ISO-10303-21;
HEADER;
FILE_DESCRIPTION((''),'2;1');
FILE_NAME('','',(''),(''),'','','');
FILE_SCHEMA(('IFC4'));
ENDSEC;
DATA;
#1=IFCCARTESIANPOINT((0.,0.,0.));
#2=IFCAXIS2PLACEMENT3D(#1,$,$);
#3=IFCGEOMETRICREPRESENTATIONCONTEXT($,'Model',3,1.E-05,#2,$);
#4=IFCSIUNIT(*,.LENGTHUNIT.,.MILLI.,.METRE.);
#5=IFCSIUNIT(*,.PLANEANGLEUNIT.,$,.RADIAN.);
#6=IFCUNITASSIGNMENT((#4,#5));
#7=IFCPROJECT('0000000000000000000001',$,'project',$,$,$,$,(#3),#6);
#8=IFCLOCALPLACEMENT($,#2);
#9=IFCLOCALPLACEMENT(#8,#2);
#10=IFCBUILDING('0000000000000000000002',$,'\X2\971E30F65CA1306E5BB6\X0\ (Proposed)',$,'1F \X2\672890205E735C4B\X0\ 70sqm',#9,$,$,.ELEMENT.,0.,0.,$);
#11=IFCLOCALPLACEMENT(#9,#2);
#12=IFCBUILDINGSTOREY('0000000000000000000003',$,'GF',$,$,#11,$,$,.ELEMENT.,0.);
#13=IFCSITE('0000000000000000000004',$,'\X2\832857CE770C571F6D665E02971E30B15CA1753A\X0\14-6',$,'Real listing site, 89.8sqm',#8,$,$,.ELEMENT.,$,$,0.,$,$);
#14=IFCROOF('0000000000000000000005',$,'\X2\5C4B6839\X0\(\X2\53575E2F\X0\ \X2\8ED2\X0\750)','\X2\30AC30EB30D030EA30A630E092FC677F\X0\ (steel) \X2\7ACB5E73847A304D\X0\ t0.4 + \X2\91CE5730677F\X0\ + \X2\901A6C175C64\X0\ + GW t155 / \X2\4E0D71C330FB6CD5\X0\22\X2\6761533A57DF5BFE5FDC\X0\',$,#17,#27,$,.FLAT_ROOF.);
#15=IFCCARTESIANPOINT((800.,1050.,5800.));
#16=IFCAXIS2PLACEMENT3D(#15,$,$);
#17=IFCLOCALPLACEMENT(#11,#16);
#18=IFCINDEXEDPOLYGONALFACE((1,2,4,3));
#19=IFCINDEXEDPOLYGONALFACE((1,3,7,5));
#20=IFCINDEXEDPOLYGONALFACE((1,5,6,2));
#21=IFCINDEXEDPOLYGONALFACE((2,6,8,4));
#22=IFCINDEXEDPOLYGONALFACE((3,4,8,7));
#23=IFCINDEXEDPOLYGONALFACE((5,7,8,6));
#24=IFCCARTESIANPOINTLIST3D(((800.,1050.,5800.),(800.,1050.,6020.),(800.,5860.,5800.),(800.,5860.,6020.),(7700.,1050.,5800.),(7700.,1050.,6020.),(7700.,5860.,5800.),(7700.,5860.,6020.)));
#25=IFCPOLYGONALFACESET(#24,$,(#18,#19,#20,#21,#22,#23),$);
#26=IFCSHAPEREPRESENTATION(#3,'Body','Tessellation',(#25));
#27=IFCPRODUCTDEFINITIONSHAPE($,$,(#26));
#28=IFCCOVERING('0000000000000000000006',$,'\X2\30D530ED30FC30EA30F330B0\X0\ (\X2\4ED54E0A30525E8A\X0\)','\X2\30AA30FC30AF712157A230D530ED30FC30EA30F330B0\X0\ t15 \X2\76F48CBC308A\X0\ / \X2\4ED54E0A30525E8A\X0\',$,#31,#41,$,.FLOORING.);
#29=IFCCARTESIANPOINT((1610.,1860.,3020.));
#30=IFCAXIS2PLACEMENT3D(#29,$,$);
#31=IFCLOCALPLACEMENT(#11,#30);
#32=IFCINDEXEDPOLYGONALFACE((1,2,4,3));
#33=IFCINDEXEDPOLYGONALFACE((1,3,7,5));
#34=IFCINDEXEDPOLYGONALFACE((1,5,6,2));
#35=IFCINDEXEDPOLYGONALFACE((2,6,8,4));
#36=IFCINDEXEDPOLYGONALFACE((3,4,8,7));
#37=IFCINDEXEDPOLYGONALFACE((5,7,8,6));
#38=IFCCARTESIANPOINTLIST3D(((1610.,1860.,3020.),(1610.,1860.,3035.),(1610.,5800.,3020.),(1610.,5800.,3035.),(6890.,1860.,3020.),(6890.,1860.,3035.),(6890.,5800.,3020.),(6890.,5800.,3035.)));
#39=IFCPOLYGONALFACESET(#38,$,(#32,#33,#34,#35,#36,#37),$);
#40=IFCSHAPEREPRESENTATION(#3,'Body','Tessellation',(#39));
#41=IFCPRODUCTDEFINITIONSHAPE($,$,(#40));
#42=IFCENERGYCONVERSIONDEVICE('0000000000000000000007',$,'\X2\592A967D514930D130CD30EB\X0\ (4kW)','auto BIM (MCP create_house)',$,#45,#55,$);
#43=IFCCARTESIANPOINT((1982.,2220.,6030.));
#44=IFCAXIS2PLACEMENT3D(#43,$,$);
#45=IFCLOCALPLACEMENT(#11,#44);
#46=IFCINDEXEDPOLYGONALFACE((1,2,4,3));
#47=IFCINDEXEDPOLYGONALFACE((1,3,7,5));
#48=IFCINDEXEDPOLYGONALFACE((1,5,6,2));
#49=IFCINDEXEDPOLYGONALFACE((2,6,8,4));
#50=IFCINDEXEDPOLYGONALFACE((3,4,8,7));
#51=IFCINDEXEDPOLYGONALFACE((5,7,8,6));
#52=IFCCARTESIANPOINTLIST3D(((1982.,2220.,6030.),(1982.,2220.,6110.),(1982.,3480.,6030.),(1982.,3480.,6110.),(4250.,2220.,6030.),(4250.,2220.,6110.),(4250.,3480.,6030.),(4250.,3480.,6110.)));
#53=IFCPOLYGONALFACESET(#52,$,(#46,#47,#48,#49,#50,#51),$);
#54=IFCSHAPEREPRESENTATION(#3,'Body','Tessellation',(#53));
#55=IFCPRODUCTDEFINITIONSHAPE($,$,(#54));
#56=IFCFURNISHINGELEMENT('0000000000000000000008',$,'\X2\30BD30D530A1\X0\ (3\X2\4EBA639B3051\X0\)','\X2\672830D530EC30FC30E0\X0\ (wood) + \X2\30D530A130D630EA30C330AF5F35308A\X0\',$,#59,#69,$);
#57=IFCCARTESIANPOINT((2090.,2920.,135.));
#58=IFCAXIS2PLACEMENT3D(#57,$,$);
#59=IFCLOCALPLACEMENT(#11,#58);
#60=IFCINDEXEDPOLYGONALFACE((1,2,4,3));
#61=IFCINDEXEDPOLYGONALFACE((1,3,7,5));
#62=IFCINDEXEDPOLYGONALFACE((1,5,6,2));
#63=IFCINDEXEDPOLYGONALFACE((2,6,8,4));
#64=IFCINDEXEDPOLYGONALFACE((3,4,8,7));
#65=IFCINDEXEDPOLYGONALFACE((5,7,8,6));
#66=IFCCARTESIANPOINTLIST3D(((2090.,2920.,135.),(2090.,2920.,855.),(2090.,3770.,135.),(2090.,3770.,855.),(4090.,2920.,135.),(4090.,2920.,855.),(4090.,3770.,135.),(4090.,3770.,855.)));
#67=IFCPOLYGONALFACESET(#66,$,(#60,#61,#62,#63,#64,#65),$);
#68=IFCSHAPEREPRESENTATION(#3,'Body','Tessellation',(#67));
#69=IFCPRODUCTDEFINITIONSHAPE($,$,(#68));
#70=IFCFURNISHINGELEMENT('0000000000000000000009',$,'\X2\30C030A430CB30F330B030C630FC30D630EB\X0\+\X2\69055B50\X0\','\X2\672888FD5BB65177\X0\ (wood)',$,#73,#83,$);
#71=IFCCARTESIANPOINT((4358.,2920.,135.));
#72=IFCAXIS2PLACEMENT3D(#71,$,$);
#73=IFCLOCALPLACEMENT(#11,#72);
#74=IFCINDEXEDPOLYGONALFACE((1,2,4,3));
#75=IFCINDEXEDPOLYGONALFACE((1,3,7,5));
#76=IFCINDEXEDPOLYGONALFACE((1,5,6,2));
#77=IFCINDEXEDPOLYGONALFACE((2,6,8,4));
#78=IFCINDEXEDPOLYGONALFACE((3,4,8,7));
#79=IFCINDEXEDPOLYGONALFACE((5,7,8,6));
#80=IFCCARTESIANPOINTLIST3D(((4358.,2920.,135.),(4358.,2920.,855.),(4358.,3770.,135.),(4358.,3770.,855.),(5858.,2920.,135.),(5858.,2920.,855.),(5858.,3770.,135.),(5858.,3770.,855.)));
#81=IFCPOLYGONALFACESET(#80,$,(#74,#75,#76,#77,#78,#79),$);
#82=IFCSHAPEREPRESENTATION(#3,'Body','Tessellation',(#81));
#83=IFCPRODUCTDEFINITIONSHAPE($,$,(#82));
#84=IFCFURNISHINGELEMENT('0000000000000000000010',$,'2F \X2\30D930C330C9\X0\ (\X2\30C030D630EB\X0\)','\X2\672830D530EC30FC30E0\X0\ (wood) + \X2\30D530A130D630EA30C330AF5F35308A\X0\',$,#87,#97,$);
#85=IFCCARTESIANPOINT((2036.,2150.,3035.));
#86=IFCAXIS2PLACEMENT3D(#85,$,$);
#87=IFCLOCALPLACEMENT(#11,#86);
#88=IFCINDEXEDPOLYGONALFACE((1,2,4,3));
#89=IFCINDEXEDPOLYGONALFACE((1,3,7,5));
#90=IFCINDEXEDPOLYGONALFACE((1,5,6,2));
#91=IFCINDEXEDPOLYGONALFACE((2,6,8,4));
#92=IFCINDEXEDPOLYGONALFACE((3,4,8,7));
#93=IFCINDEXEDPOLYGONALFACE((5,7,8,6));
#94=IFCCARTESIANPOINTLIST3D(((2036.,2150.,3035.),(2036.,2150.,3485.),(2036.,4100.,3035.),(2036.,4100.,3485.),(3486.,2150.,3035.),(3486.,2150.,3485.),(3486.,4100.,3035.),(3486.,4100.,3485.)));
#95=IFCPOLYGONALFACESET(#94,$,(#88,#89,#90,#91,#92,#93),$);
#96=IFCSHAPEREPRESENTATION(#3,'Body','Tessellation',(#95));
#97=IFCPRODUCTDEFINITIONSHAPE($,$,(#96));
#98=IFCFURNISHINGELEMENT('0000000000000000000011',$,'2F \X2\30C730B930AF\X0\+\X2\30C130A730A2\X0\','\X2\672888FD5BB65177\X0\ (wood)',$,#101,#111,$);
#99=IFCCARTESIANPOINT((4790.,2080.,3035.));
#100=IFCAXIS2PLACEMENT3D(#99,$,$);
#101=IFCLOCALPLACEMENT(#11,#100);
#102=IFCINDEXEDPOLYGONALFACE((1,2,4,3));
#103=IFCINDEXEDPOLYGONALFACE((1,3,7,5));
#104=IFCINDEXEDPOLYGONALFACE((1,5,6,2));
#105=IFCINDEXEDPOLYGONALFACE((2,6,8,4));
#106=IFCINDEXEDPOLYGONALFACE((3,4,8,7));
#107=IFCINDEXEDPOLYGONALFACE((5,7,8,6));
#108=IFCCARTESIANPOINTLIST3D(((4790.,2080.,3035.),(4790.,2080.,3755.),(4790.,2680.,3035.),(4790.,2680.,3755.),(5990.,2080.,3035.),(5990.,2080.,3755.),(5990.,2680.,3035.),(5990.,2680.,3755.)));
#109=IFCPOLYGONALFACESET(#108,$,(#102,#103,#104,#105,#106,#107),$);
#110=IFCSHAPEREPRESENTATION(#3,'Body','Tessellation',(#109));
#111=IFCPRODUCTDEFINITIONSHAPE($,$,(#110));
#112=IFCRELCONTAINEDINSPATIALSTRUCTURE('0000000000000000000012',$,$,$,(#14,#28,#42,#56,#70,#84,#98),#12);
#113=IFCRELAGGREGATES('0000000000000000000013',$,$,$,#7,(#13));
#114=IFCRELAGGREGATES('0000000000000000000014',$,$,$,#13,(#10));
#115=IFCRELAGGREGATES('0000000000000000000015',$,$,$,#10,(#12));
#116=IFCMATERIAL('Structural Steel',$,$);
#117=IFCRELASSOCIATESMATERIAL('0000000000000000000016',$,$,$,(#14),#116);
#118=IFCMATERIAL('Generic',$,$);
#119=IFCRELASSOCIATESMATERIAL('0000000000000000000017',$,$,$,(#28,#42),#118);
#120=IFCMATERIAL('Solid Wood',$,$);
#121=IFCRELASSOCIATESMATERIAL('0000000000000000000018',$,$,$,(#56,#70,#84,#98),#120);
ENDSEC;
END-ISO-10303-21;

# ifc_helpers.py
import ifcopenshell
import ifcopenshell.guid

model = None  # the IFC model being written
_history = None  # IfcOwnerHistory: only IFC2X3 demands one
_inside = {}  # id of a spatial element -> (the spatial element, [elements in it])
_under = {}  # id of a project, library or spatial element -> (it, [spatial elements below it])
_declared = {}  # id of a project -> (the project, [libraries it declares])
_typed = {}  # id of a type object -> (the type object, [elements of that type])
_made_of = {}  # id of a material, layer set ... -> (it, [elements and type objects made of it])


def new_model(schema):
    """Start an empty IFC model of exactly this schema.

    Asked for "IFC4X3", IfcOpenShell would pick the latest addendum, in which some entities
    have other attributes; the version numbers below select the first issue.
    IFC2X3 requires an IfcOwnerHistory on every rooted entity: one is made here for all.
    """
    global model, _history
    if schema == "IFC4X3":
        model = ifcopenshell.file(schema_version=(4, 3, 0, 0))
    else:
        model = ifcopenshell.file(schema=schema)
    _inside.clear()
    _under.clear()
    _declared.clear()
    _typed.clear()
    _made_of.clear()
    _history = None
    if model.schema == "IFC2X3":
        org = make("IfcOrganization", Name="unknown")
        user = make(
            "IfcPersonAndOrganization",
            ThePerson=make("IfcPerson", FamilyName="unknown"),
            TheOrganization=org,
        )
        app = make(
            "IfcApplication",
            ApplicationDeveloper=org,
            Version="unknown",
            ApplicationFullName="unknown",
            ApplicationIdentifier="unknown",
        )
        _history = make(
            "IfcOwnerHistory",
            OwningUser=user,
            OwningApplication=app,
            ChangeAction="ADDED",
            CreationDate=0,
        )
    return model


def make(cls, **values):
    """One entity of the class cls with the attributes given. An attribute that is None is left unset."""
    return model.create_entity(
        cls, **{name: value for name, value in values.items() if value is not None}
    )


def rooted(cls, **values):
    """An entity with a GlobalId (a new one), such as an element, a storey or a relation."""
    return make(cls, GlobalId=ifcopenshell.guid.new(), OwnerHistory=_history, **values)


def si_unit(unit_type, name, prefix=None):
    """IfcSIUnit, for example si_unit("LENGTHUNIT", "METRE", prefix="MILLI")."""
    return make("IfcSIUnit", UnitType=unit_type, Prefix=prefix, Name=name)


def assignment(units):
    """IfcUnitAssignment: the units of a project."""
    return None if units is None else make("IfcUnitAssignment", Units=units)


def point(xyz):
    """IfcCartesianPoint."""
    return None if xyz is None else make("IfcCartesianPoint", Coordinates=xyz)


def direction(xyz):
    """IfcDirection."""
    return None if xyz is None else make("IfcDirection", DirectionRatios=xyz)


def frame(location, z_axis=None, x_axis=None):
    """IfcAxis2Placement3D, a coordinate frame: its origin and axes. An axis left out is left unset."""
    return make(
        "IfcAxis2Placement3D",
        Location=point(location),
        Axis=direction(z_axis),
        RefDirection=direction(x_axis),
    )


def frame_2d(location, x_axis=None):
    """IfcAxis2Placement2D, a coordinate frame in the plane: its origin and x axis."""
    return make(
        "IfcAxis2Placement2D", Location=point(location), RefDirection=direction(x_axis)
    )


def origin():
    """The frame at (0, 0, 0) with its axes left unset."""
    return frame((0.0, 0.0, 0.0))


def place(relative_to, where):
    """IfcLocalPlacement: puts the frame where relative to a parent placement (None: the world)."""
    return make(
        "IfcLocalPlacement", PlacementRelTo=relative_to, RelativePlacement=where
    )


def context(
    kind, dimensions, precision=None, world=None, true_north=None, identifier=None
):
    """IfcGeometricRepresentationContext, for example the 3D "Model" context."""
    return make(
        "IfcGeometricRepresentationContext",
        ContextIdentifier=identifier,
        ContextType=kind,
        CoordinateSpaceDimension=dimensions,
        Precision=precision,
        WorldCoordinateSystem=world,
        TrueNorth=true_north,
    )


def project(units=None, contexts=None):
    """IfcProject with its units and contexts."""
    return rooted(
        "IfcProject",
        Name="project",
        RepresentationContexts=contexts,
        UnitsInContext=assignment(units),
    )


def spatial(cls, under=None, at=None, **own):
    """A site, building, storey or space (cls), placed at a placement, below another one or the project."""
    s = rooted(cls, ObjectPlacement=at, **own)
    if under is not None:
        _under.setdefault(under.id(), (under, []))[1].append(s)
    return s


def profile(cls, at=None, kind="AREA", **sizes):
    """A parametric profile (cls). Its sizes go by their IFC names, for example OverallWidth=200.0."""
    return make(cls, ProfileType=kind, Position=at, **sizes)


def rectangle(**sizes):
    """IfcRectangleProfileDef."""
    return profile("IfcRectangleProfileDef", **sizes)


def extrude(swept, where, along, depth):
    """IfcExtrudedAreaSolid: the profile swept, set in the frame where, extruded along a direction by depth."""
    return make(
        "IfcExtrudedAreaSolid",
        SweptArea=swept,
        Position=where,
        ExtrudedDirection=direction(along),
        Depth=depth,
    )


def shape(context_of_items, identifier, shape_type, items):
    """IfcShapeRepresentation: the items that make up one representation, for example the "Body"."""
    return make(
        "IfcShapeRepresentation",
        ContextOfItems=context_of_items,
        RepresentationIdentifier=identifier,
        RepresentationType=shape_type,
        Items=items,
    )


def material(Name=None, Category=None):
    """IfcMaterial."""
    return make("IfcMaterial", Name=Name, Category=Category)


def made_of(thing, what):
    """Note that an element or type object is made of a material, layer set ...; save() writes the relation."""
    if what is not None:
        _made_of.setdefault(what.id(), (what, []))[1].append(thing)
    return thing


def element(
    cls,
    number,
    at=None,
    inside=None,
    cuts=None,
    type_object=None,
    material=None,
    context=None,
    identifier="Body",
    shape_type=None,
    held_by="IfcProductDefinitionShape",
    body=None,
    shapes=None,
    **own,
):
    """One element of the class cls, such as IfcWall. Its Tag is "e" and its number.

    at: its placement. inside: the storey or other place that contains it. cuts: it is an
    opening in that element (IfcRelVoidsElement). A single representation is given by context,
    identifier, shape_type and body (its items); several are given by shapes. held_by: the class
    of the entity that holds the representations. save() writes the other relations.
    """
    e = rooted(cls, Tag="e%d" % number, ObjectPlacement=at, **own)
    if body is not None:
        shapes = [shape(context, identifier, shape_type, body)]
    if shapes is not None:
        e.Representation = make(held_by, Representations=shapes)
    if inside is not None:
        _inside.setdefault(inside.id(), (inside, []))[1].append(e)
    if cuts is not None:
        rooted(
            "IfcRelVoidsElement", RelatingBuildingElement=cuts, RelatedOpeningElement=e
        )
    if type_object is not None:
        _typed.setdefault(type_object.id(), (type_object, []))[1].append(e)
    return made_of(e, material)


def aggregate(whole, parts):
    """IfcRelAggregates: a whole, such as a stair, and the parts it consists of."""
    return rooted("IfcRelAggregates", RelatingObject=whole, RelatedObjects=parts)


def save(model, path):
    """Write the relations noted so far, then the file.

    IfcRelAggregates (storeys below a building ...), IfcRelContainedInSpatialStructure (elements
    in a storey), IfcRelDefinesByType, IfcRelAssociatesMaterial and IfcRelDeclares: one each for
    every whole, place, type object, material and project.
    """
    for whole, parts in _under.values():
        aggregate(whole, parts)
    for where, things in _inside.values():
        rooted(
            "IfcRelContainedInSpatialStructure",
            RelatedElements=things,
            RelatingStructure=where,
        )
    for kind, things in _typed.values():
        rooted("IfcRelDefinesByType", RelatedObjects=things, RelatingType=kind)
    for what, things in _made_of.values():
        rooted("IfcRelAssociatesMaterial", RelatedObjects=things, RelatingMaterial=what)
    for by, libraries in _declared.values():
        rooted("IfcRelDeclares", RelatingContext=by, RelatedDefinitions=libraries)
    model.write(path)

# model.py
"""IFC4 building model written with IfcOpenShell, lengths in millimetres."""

from ifc_helpers import new_model, si_unit, frame, frame_2d, origin, place, context, project, spatial, rectangle, extrude, material, element, save


model = new_model("IFC4")

# Units and contexts
model_context = context("Model", 3, precision=1e-05, world=origin())
ifc_project = project(units=[si_unit("LENGTHUNIT", "METRE", prefix="MILLI"), si_unit("PLANEANGLEUNIT", "RADIAN")], contexts=[model_context])

# Site, building, storey
site_placement = place(None, origin())
site = spatial("IfcSite", under=ifc_project, at=site_placement, Name="茨城県土浦市霞ケ岡町14-6", ObjectType="Real listing site, 89.8sqm", CompositionType="ELEMENT", RefElevation=0.0)
building_placement = place(site_placement, origin())
building = spatial("IfcBuilding", under=site, at=building_placement, Name="霞ヶ岡の家 (Proposed)", ObjectType="1F 木造平屋 70sqm", CompositionType="ELEMENT", ElevationOfRefHeight=0.0, ElevationOfTerrain=0.0)
storey_placement = place(building_placement, origin())
storey = spatial("IfcBuildingStorey", under=building, at=storey_placement, Name="GF", CompositionType="ELEMENT", Elevation=0.0)

# Shared definitions
ifc_material_1 = material(Name="Solid Wood")

# Shared definitions
ifc_material_2 = material(Name="Generic")

# Roof
ifc_material_3 = material(Name="Structural Steel")
for number, where, name in (
    (1, (800.0, 1050.0, 5800.0), "屋根(南帯 軒750)"),
):
    element("IfcRoof", number, at=place(storey_placement, frame(where)), inside=storey, material=ifc_material_3, Name=name, Description="ガルバリウム鋼板 (steel) 立平葺き t0.4 + 野地板 + 通気層 + GW t155 / 不燃・法22条区域対応", PredefinedType="FLAT_ROOF", context=model_context, shape_type="SweptSolid", body=[
        extrude(rectangle(XDim=6900.0, YDim=4810.0, at=frame_2d((3450.0, 2405.0))), frame((800.0, 1050.0, 5800.0)), (0.0, 0.0, 1.0), 220.0),
    ])

# Covering
covering_placement = place(storey_placement, frame((1610.0, 1860.0, 3020.0)))
element("IfcCovering", 2, at=covering_placement, inside=storey, material=ifc_material_2, Name="フローリング (仕上げ床)", Description="オーク無垢フローリング t15 直貼り / 仕上げ床", PredefinedType="FLOORING", context=model_context, shape_type="SweptSolid", body=[
    extrude(rectangle(XDim=5280.0, YDim=3940.0, at=frame_2d((2640.0, 1970.0))), frame((1610.0, 1860.0, 3020.0)), (0.0, 0.0, 1.0), 15.0),
])

# Energy conversion device
energy_conversion_device_placement = place(storey_placement, frame((1982.0, 2220.0, 6030.0)))
element("IfcEnergyConversionDevice", 3, at=energy_conversion_device_placement, inside=storey, material=ifc_material_2, Name="太陽光パネル (4kW)", Description="auto BIM (MCP create_house)", context=model_context, shape_type="SweptSolid", body=[
    extrude(rectangle(XDim=2268.0, YDim=1260.0, at=frame_2d((1134.0, 630.0))), frame((1982.0, 2220.0, 6030.0)), (0.0, 0.0, 1.0), 80.0),
])

# Furnishing elements
furnishing_1_placement = place(storey_placement, frame((2090.0, 2920.0, 135.0)))
element("IfcFurnishingElement", 4, at=furnishing_1_placement, inside=storey, material=ifc_material_1, Name="ソファ (3人掛け)", Description="木フレーム (wood) + ファブリック張り", context=model_context, shape_type="SweptSolid", body=[
    extrude(rectangle(XDim=2000.0, YDim=850.0, at=frame_2d((1000.0, 425.0))), frame((2090.0, 2920.0, 135.0)), (0.0, 0.0, 1.0), 720.0),
])
furnishing_2_placement = place(storey_placement, frame((4358.0, 2920.0, 135.0)))
element("IfcFurnishingElement", 5, at=furnishing_2_placement, inside=storey, material=ifc_material_1, Name="ダイニングテーブル+椅子", Description="木製家具 (wood)", context=model_context, shape_type="SweptSolid", body=[
    extrude(rectangle(XDim=1500.0, YDim=850.0, at=frame_2d((750.0, 425.0))), frame((4358.0, 2920.0, 135.0)), (0.0, 0.0, 1.0), 720.0),
])
furnishing_3_placement = place(storey_placement, frame((2036.0, 2150.0, 3035.0)))
element("IfcFurnishingElement", 6, at=furnishing_3_placement, inside=storey, material=ifc_material_1, Name="2F ベッド (ダブル)", Description="木フレーム (wood) + ファブリック張り", context=model_context, shape_type="SweptSolid", body=[
    extrude(rectangle(XDim=1450.0, YDim=1950.0, at=frame_2d((725.0, 975.0))), frame((2036.0, 2150.0, 3035.0)), (0.0, 0.0, 1.0), 450.0),
])
furnishing_4_placement = place(storey_placement, frame((4790.0, 2080.0, 3035.0)))
element("IfcFurnishingElement", 7, at=furnishing_4_placement, inside=storey, material=ifc_material_1, Name="2F デスク+チェア", Description="木製家具 (wood)", context=model_context, shape_type="SweptSolid", body=[
    extrude(rectangle(XDim=1200.0, YDim=600.0, at=frame_2d((600.0, 300.0))), frame((4790.0, 2080.0, 3035.0)), (0.0, 0.0, 1.0), 720.0),
])

save(model, "model.ifc")
